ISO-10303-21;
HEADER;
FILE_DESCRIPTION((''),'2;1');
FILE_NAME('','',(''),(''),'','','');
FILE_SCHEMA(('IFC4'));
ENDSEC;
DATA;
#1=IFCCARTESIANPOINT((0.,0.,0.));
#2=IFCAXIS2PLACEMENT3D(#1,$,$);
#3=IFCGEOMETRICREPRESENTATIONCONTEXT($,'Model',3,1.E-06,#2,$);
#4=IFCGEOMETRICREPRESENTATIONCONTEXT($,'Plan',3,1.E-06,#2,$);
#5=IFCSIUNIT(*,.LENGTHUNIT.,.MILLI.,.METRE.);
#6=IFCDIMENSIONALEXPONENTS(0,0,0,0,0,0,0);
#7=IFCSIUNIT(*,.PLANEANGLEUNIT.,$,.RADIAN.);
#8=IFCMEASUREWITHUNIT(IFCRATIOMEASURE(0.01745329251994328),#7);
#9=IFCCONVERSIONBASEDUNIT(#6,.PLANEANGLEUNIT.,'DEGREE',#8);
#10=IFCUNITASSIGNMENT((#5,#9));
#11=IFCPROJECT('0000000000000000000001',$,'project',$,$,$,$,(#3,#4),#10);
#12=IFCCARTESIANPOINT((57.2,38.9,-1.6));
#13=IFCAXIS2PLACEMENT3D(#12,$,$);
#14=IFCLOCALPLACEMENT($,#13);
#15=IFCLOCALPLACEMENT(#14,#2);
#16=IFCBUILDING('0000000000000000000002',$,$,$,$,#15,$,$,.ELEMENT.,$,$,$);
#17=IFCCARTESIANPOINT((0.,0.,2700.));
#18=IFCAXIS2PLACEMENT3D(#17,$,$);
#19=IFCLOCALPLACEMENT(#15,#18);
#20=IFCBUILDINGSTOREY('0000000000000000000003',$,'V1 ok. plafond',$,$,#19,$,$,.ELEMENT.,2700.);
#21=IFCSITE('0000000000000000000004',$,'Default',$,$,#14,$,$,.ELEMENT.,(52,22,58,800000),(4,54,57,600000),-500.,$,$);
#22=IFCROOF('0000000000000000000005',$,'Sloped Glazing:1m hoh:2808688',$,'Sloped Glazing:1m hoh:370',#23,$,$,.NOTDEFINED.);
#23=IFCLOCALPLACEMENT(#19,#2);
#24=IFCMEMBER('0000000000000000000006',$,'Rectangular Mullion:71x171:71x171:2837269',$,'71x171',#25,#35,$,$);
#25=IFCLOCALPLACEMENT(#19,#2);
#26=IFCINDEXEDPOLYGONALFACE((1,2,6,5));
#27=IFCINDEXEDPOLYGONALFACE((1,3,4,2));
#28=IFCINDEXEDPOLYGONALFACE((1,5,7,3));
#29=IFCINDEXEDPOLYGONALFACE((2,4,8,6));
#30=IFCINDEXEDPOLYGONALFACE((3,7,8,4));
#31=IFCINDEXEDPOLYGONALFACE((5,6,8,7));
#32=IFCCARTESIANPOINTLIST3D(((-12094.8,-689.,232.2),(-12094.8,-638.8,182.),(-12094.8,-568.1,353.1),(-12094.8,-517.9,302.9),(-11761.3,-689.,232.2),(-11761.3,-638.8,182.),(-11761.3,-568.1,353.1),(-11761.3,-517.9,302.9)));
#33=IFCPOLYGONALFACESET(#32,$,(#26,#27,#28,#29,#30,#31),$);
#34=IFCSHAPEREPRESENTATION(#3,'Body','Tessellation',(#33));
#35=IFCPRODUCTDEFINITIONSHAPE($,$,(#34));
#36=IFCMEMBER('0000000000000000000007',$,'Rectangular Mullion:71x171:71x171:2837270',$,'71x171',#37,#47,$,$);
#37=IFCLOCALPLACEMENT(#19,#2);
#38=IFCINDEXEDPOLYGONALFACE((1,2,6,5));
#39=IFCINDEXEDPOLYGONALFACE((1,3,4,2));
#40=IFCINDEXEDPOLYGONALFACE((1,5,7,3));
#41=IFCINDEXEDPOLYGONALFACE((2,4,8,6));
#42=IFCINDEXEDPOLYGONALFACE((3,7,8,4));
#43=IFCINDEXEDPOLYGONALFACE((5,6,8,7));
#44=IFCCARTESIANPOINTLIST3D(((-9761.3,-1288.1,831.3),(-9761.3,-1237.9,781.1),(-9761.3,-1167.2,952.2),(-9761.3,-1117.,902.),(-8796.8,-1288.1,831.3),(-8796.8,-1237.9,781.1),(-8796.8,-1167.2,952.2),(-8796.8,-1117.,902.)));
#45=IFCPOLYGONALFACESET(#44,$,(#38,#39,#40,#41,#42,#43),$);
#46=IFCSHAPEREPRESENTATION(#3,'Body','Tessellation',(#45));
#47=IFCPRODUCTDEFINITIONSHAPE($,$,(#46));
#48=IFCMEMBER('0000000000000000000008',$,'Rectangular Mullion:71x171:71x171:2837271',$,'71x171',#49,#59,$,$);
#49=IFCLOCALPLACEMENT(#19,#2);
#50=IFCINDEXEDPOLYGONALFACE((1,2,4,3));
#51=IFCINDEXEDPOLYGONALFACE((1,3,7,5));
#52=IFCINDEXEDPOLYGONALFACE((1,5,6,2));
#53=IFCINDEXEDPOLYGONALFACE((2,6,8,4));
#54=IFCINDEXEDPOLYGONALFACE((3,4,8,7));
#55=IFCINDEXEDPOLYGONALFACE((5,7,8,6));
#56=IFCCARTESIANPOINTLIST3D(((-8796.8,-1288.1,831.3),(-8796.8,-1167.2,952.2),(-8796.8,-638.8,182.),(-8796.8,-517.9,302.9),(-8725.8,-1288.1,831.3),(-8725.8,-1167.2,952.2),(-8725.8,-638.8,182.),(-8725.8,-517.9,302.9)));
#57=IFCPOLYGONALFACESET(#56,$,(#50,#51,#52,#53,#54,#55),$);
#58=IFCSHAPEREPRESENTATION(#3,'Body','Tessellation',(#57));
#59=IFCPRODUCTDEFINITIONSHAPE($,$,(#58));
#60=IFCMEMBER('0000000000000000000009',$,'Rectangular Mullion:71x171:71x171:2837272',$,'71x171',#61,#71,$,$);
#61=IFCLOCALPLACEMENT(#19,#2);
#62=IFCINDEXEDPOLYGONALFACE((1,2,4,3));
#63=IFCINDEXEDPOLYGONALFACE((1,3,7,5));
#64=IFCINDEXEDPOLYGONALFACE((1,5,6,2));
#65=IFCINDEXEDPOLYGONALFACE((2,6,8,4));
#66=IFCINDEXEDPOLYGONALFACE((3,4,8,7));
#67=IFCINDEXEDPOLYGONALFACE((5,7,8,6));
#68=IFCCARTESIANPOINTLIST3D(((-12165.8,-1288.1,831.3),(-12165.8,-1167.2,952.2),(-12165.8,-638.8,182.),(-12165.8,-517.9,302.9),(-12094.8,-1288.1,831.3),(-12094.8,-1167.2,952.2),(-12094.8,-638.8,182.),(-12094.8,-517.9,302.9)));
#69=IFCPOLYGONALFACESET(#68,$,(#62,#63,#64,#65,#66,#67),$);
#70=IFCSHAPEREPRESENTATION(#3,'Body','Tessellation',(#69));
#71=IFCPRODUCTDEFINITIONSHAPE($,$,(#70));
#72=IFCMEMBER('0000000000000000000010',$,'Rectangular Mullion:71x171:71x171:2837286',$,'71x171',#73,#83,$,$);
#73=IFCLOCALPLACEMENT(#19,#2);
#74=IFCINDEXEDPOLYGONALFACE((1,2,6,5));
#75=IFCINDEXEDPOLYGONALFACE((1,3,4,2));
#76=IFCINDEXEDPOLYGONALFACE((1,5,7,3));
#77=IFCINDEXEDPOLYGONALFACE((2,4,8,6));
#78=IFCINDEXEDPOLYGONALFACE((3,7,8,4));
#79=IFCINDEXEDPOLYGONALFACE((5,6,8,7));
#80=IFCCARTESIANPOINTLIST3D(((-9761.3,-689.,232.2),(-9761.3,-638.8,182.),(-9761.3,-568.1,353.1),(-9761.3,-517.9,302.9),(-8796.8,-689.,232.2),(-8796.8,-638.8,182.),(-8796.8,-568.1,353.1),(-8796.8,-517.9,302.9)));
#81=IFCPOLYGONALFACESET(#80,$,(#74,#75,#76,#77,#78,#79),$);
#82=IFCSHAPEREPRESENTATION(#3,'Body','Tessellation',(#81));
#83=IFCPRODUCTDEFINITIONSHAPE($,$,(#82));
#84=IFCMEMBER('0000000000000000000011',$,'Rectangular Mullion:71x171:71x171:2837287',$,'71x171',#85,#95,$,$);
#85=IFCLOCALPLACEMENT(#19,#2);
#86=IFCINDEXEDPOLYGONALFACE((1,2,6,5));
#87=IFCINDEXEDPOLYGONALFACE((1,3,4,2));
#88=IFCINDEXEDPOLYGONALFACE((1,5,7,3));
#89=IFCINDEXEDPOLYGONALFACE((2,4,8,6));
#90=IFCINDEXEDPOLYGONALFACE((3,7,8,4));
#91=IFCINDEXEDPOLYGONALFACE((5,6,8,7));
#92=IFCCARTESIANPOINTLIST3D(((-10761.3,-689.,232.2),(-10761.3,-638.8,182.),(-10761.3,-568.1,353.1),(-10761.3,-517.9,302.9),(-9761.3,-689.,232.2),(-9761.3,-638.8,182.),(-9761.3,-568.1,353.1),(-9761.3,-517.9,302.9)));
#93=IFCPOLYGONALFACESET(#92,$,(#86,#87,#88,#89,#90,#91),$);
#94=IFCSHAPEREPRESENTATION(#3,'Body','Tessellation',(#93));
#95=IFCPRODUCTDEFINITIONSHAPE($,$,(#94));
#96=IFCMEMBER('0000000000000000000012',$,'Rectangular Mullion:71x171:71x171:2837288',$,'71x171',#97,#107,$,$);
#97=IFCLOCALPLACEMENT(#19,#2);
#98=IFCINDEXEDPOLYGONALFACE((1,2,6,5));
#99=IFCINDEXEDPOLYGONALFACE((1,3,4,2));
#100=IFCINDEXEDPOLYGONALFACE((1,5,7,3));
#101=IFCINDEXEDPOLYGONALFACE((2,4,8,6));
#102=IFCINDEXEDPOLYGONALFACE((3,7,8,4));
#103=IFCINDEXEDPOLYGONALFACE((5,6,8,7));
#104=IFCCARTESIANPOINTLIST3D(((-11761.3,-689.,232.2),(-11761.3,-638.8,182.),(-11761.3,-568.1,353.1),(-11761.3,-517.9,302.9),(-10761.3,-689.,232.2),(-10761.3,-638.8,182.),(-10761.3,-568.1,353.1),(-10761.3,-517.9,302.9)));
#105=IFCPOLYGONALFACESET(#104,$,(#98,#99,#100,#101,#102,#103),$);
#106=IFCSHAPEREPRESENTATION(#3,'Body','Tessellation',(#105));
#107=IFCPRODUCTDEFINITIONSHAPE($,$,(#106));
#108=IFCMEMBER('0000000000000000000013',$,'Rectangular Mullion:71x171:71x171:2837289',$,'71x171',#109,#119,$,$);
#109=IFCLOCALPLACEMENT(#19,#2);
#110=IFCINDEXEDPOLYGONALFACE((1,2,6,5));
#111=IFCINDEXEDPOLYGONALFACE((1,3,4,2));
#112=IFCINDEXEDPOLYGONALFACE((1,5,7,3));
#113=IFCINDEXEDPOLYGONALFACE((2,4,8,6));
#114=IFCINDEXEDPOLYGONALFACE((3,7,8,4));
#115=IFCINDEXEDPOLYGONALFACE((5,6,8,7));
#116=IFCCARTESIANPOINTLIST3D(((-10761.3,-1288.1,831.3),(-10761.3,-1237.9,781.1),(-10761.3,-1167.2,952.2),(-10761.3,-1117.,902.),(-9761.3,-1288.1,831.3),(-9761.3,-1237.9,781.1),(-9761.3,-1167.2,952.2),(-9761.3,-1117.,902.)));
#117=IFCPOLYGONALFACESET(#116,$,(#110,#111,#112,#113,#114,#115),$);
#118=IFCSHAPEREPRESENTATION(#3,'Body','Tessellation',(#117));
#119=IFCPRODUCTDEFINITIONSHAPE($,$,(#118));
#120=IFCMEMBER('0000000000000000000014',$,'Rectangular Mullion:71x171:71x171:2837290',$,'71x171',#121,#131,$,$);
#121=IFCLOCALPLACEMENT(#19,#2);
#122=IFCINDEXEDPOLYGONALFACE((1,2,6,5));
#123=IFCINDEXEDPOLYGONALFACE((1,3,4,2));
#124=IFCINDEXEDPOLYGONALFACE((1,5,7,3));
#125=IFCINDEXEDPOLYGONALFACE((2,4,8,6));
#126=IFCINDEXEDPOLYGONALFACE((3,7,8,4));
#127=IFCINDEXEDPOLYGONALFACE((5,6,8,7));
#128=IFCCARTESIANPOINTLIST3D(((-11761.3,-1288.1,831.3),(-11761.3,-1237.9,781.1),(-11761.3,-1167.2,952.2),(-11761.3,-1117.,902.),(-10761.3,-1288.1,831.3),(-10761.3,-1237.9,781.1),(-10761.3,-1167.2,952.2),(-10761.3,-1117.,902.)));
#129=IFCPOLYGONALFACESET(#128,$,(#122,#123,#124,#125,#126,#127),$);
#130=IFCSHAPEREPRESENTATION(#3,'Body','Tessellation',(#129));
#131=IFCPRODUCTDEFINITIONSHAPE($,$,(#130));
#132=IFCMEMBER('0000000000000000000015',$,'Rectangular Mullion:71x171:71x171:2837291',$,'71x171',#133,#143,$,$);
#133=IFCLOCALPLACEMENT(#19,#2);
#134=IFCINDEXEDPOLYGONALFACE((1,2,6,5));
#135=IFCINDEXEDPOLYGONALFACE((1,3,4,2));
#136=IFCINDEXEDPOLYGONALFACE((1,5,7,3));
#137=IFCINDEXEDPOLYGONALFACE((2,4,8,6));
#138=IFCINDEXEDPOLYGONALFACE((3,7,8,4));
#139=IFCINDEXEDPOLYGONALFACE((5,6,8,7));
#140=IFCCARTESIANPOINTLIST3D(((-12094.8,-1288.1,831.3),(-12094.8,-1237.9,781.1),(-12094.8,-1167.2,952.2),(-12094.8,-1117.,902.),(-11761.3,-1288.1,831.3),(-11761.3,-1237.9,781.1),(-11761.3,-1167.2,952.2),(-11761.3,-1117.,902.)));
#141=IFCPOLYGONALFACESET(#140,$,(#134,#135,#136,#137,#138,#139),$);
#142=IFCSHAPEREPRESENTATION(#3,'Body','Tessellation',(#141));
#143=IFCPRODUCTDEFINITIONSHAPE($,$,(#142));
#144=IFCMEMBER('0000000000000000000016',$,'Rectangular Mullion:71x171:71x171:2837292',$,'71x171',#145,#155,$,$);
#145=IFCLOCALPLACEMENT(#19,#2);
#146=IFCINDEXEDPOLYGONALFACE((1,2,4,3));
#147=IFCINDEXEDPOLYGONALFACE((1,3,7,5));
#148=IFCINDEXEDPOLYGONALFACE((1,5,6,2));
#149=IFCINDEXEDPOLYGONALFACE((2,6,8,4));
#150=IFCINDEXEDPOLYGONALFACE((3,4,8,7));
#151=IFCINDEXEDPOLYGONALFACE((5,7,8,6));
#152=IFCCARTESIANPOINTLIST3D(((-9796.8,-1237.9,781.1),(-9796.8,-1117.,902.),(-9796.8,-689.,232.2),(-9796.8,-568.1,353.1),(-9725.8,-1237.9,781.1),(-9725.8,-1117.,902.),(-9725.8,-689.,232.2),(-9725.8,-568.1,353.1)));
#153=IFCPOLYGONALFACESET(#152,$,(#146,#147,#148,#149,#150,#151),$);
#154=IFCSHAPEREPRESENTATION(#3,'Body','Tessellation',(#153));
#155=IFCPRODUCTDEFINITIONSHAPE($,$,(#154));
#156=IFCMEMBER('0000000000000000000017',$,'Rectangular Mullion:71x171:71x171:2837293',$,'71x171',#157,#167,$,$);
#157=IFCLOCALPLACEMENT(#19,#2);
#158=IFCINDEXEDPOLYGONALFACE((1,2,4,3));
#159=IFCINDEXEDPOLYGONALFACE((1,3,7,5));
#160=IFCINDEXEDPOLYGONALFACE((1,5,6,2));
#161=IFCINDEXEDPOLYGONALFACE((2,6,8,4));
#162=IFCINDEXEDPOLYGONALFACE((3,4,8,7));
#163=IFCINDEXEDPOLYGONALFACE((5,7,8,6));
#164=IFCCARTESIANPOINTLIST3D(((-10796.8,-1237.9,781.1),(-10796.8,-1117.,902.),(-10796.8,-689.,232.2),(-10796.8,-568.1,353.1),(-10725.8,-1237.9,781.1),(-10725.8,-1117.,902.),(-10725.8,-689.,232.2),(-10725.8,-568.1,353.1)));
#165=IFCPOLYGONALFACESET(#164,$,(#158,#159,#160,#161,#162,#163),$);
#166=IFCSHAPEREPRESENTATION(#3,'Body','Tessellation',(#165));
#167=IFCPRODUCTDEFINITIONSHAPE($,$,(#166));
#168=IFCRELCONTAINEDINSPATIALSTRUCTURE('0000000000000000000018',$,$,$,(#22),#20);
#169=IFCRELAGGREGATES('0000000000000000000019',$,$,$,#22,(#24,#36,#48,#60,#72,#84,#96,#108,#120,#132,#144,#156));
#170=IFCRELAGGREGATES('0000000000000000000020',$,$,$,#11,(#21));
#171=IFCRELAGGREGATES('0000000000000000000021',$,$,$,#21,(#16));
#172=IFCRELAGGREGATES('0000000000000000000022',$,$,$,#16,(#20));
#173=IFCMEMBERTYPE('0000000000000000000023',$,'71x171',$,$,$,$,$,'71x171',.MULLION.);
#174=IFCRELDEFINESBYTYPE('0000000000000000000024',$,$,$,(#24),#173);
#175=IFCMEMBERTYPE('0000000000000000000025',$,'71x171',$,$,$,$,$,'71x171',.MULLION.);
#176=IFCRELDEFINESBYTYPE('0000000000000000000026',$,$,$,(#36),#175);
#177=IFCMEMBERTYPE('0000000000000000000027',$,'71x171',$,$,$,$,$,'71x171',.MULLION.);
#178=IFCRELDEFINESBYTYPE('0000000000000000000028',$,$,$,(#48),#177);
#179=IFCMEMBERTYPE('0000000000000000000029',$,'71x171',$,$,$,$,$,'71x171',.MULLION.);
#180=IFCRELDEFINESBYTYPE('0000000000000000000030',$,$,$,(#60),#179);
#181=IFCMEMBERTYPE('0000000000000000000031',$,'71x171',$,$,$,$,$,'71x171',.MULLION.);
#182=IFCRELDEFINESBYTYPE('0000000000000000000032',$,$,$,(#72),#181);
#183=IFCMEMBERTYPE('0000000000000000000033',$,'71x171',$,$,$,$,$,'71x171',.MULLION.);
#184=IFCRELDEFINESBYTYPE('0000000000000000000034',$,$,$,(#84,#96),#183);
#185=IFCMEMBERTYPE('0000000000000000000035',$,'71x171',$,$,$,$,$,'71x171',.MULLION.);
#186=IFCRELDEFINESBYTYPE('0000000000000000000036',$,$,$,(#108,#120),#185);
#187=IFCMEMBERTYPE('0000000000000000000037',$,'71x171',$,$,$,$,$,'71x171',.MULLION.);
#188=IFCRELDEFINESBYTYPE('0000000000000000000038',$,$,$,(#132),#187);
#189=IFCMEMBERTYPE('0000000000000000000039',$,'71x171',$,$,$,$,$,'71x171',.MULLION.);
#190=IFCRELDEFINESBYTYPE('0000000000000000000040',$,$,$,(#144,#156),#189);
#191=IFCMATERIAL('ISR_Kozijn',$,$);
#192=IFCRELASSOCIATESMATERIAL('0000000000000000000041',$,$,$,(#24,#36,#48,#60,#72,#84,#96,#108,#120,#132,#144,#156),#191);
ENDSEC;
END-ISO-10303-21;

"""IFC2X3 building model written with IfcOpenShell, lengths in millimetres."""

from ifc_helpers import new_model, entity, si_unit, converted_unit, frame, origin, origin_2d_with_axis, place, context, project, spatial, rectangle, extrude, source, transform, mapped, material, type_object, type_shapes, element, aggregate, save


model = new_model("IFC2X3")

# Units and contexts
model_context = context("Model", 3, precision=1e-06, world=origin())
plan_context = context("Plan", 3, precision=1e-06, world=origin())
ifc_project = project(units=[si_unit("LENGTHUNIT", "METRE", prefix="MILLI"), converted_unit("PLANEANGLEUNIT", "DEGREE", entity("IfcRatioMeasure", 0.01745329251994328), si_unit("PLANEANGLEUNIT", "RADIAN"), dimensions=[0, 0, 0, 0, 0, 0, 0])], contexts=[model_context, plan_context])

# Site, building, storey
site_placement = place(None, frame((57.2, 38.9, -1.6)))
site = spatial("IfcSite", under=ifc_project, at=site_placement, Name="Default", CompositionType="ELEMENT", RefLatitude=(52, 22, 58, 800000), RefLongitude=(4, 54, 57, 600000), RefElevation=-500.0)
building_placement = place(site_placement, origin())
building = spatial("IfcBuilding", under=site, at=building_placement, CompositionType="ELEMENT")
storey_placement = place(building_placement, frame((0.0, 0.0, 2700.0)))
storey = spatial("IfcBuildingStorey", under=building, at=storey_placement, Name="V1 ok. plafond", CompositionType="ELEMENT", Elevation=2700.0)

# Roof, members
roof_placement = place(storey_placement, origin())
roof = element("IfcRoof", 1, at=roof_placement, inside=storey, Name="Sloped Glazing:1m hoh:2808688", ObjectType="Sloped Glazing:1m hoh:370", ShapeType="NOTDEFINED")
ifc_material_1 = material(Name="ISR_Kozijn")
member_type_1 = type_object("IfcMemberType", Name="71x171", ElementType="71x171", PredefinedType="MULLION")
shared_shape_1 = source(origin(), model_context, "Body", "SweptSolid", [
    extrude(rectangle(XDim=71.0, YDim=171.0, at=origin_2d_with_axis()), frame((-35.5, 0.0, -333.5), z_axis=(0.0, 0.0, 1.0), x_axis=(-1.0, 0.0, 0.0)), (0.0, 0.0, 1.0), 333.5),
])
type_shapes(member_type_1, [shared_shape_1])
placement = place(building_placement, frame((0.0, 0.0, 2970.0)))
member_1_placement = place(placement, frame((-12094.8, -578.3, -27.6), z_axis=(-1.0, 0.0, 0.0), x_axis=(0.0, 0.707107, -0.707107)))
member_1 = element("IfcMember", 2, at=member_1_placement, type_object=member_type_1, material=ifc_material_1, Name="Rectangular Mullion:71x171:71x171:2837269", ObjectType="71x171", context=model_context, shape_type="MappedRepresentation", body=[
    mapped(shared_shape_1, transform((0.0, 0.0, 0.0), scale=1.0)),
])
member_type_2 = type_object("IfcMemberType", Name="71x171", ElementType="71x171", PredefinedType="MULLION")
shared_shape_2 = source(origin(), model_context, "Body", "SweptSolid", [
    extrude(rectangle(XDim=71.0, YDim=171.0, at=origin_2d_with_axis()), frame((-35.5, 0.0, -964.5), z_axis=(0.0, 0.0, 1.0), x_axis=(-1.0, 0.0, 0.0)), (0.0, 0.0, 1.0), 964.5),
])
type_shapes(member_type_2, [shared_shape_2])
member_2_placement = place(placement, frame((-8796.8, -1227.6, 621.7), z_axis=(1.0, 0.0, 0.0), x_axis=(0.0, -0.707107, 0.707107)))
member_2 = element("IfcMember", 3, at=member_2_placement, type_object=member_type_2, material=ifc_material_1, Name="Rectangular Mullion:71x171:71x171:2837270", ObjectType="71x171", context=model_context, shape_type="MappedRepresentation", body=[
    mapped(shared_shape_2, transform((0.0, 0.0, 0.0), scale=1.0)),
])
member_type_3 = type_object("IfcMemberType", Name="71x171", ElementType="71x171", PredefinedType="MULLION")
shared_shape_3 = source(origin(), model_context, "Body", "SweptSolid", [
    extrude(rectangle(XDim=71.0, YDim=171.0, at=origin_2d_with_axis()), frame((-35.5, 0.0, -918.2), z_axis=(0.0, 0.0, 1.0), x_axis=(-1.0, 0.0, 0.0)), (0.0, 0.0, 1.0), 918.2),
])
type_shapes(member_type_3, [shared_shape_3])
member_3_placement = place(placement, frame((-8725.8, -578.3, -27.6), z_axis=(0.0, 0.707107, -0.707107), x_axis=(1.0, 0.0, 0.0)))
member_3 = element("IfcMember", 4, at=member_3_placement, type_object=member_type_3, material=ifc_material_1, Name="Rectangular Mullion:71x171:71x171:2837271", ObjectType="71x171", context=model_context, shape_type="MappedRepresentation", body=[
    mapped(shared_shape_3, transform((0.0, 0.0, 0.0), scale=1.0)),
])
member_type_4 = type_object("IfcMemberType", Name="71x171", ElementType="71x171", PredefinedType="MULLION")
shared_shape_4 = source(origin(), model_context, "Body", "SweptSolid", [
    extrude(rectangle(XDim=71.0, YDim=171.0, at=origin_2d_with_axis()), frame((-35.5, 0.0, -918.2), z_axis=(0.0, 0.0, 1.0), x_axis=(-1.0, 0.0, 0.0)), (0.0, 0.0, 1.0), 918.2),
])
type_shapes(member_type_4, [shared_shape_4])
member_4_placement = place(placement, frame((-12165.8, -1227.6, 621.7), z_axis=(0.0, -0.707107, 0.707107), x_axis=(-1.0, 0.0, 0.0)))
member_4 = element("IfcMember", 5, at=member_4_placement, type_object=member_type_4, material=ifc_material_1, Name="Rectangular Mullion:71x171:71x171:2837272", ObjectType="71x171", context=model_context, shape_type="MappedRepresentation", body=[
    mapped(shared_shape_4, transform((0.0, 0.0, 0.0), scale=1.0)),
])
member_type_5 = type_object("IfcMemberType", Name="71x171", ElementType="71x171", PredefinedType="MULLION")
shared_shape_5 = source(origin(), model_context, "Body", "SweptSolid", [
    extrude(rectangle(XDim=71.0, YDim=171.0, at=origin_2d_with_axis()), frame((-35.5, 0.0, -964.5), z_axis=(0.0, 0.0, 1.0), x_axis=(-1.0, 0.0, 0.0)), (0.0, 0.0, 1.0), 964.5),
])
type_shapes(member_type_5, [shared_shape_5])
member_5_placement = place(placement, frame((-9761.3, -578.3, -27.6), z_axis=(-1.0, 0.0, 0.0), x_axis=(0.0, 0.707107, -0.707107)))
member_5 = element("IfcMember", 6, at=member_5_placement, type_object=member_type_5, material=ifc_material_1, Name="Rectangular Mullion:71x171:71x171:2837286", ObjectType="71x171", context=model_context, shape_type="MappedRepresentation", body=[
    mapped(shared_shape_5, transform((0.0, 0.0, 0.0), scale=1.0)),
])
member_type_6 = type_object("IfcMemberType", Name="71x171", ElementType="71x171", PredefinedType="MULLION")
shared_shape_6 = source(origin(), model_context, "Body", "SweptSolid", [
    extrude(rectangle(XDim=71.0, YDim=171.0, at=origin_2d_with_axis()), frame((-35.5, 0.0, -1000.0), z_axis=(0.0, 0.0, 1.0), x_axis=(-1.0, 0.0, 0.0)), (0.0, 0.0, 1.0), 1000.0),
])
type_shapes(member_type_6, [shared_shape_6])
member_6_placement = place(placement, frame((-10761.3, -578.3, -27.6), z_axis=(-1.0, 0.0, 0.0), x_axis=(0.0, 0.707107, -0.707107)))
member_6 = element("IfcMember", 7, at=member_6_placement, type_object=member_type_6, material=ifc_material_1, Name="Rectangular Mullion:71x171:71x171:2837287", ObjectType="71x171", context=model_context, shape_type="MappedRepresentation", body=[
    mapped(shared_shape_6, transform((0.0, 0.0, 0.0), scale=1.0)),
])
member_7_placement = place(placement, frame((-11761.3, -578.3, -27.6), z_axis=(-1.0, 0.0, 0.0), x_axis=(0.0, 0.707107, -0.707107)))
member_7 = element("IfcMember", 8, at=member_7_placement, type_object=member_type_6, material=ifc_material_1, Name="Rectangular Mullion:71x171:71x171:2837288", ObjectType="71x171", context=model_context, shape_type="MappedRepresentation", body=[
    mapped(shared_shape_6, transform((0.0, 0.0, 0.0), scale=1.0)),
])
member_type_7 = type_object("IfcMemberType", Name="71x171", ElementType="71x171", PredefinedType="MULLION")
shared_shape_7 = source(origin(), model_context, "Body", "SweptSolid", [
    extrude(rectangle(XDim=71.0, YDim=171.0, at=origin_2d_with_axis()), frame((-35.5, 0.0, -1000.0), z_axis=(0.0, 0.0, 1.0), x_axis=(-1.0, 0.0, 0.0)), (0.0, 0.0, 1.0), 1000.0),
])
type_shapes(member_type_7, [shared_shape_7])
member_8_placement = place(placement, frame((-9761.3, -1227.6, 621.7), z_axis=(1.0, 0.0, 0.0), x_axis=(0.0, -0.707107, 0.707107)))
member_8 = element("IfcMember", 9, at=member_8_placement, type_object=member_type_7, material=ifc_material_1, Name="Rectangular Mullion:71x171:71x171:2837289", ObjectType="71x171", context=model_context, shape_type="MappedRepresentation", body=[
    mapped(shared_shape_7, transform((0.0, 0.0, 0.0), scale=1.0)),
])
member_9_placement = place(placement, frame((-10761.3, -1227.6, 621.7), z_axis=(1.0, 0.0, 0.0), x_axis=(0.0, -0.707107, 0.707107)))
member_9 = element("IfcMember", 10, at=member_9_placement, type_object=member_type_7, material=ifc_material_1, Name="Rectangular Mullion:71x171:71x171:2837290", ObjectType="71x171", context=model_context, shape_type="MappedRepresentation", body=[
    mapped(shared_shape_7, transform((0.0, 0.0, 0.0), scale=1.0)),
])
member_type_8 = type_object("IfcMemberType", Name="71x171", ElementType="71x171", PredefinedType="MULLION")
shared_shape_8 = source(origin(), model_context, "Body", "SweptSolid", [
    extrude(rectangle(XDim=71.0, YDim=171.0, at=origin_2d_with_axis()), frame((-35.5, 0.0, -333.5), z_axis=(0.0, 0.0, 1.0), x_axis=(-1.0, 0.0, 0.0)), (0.0, 0.0, 1.0), 333.5),
])
type_shapes(member_type_8, [shared_shape_8])
member_10_placement = place(placement, frame((-11761.3, -1227.6, 621.7), z_axis=(1.0, 0.0, 0.0), x_axis=(0.0, -0.707107, 0.707107)))
member_10 = element("IfcMember", 11, at=member_10_placement, type_object=member_type_8, material=ifc_material_1, Name="Rectangular Mullion:71x171:71x171:2837291", ObjectType="71x171", context=model_context, shape_type="MappedRepresentation", body=[
    mapped(shared_shape_8, transform((0.0, 0.0, 0.0), scale=1.0)),
])
member_type_9 = type_object("IfcMemberType", Name="71x171", ElementType="71x171", PredefinedType="MULLION")
shared_shape_9 = source(origin(), model_context, "Body", "SweptSolid", [
    extrude(rectangle(XDim=71.0, YDim=171.0, at=origin_2d_with_axis()), frame((0.0, 0.0, -776.2), z_axis=(0.0, 0.0, 1.0), x_axis=(-1.0, 0.0, 0.0)), (0.0, 0.0, 1.0), 776.2),
])
type_shapes(member_type_9, [shared_shape_9])
member_11_placement = place(placement, frame((-9761.3, -1177.4, 571.5), z_axis=(0.0, -0.707107, 0.707107), x_axis=(-1.0, 0.0, 0.0)))
member_11 = element("IfcMember", 12, at=member_11_placement, type_object=member_type_9, material=ifc_material_1, Name="Rectangular Mullion:71x171:71x171:2837292", ObjectType="71x171", context=model_context, shape_type="MappedRepresentation", body=[
    mapped(shared_shape_9, transform((0.0, 0.0, 0.0), scale=1.0)),
])
member_12_placement = place(placement, frame((-10761.3, -1177.4, 571.5), z_axis=(0.0, -0.707107, 0.707107), x_axis=(-1.0, 0.0, 0.0)))
member_12 = element("IfcMember", 13, at=member_12_placement, type_object=member_type_9, material=ifc_material_1, Name="Rectangular Mullion:71x171:71x171:2837293", ObjectType="71x171", context=model_context, shape_type="MappedRepresentation", body=[
    mapped(shared_shape_9, transform((0.0, 0.0, 0.0), scale=1.0)),
])
aggregate(roof, [member_1, member_2, member_3, member_4, member_5, member_6, member_7, member_8, member_9, member_10, member_11, member_12])

save(model, "model.ifc")
